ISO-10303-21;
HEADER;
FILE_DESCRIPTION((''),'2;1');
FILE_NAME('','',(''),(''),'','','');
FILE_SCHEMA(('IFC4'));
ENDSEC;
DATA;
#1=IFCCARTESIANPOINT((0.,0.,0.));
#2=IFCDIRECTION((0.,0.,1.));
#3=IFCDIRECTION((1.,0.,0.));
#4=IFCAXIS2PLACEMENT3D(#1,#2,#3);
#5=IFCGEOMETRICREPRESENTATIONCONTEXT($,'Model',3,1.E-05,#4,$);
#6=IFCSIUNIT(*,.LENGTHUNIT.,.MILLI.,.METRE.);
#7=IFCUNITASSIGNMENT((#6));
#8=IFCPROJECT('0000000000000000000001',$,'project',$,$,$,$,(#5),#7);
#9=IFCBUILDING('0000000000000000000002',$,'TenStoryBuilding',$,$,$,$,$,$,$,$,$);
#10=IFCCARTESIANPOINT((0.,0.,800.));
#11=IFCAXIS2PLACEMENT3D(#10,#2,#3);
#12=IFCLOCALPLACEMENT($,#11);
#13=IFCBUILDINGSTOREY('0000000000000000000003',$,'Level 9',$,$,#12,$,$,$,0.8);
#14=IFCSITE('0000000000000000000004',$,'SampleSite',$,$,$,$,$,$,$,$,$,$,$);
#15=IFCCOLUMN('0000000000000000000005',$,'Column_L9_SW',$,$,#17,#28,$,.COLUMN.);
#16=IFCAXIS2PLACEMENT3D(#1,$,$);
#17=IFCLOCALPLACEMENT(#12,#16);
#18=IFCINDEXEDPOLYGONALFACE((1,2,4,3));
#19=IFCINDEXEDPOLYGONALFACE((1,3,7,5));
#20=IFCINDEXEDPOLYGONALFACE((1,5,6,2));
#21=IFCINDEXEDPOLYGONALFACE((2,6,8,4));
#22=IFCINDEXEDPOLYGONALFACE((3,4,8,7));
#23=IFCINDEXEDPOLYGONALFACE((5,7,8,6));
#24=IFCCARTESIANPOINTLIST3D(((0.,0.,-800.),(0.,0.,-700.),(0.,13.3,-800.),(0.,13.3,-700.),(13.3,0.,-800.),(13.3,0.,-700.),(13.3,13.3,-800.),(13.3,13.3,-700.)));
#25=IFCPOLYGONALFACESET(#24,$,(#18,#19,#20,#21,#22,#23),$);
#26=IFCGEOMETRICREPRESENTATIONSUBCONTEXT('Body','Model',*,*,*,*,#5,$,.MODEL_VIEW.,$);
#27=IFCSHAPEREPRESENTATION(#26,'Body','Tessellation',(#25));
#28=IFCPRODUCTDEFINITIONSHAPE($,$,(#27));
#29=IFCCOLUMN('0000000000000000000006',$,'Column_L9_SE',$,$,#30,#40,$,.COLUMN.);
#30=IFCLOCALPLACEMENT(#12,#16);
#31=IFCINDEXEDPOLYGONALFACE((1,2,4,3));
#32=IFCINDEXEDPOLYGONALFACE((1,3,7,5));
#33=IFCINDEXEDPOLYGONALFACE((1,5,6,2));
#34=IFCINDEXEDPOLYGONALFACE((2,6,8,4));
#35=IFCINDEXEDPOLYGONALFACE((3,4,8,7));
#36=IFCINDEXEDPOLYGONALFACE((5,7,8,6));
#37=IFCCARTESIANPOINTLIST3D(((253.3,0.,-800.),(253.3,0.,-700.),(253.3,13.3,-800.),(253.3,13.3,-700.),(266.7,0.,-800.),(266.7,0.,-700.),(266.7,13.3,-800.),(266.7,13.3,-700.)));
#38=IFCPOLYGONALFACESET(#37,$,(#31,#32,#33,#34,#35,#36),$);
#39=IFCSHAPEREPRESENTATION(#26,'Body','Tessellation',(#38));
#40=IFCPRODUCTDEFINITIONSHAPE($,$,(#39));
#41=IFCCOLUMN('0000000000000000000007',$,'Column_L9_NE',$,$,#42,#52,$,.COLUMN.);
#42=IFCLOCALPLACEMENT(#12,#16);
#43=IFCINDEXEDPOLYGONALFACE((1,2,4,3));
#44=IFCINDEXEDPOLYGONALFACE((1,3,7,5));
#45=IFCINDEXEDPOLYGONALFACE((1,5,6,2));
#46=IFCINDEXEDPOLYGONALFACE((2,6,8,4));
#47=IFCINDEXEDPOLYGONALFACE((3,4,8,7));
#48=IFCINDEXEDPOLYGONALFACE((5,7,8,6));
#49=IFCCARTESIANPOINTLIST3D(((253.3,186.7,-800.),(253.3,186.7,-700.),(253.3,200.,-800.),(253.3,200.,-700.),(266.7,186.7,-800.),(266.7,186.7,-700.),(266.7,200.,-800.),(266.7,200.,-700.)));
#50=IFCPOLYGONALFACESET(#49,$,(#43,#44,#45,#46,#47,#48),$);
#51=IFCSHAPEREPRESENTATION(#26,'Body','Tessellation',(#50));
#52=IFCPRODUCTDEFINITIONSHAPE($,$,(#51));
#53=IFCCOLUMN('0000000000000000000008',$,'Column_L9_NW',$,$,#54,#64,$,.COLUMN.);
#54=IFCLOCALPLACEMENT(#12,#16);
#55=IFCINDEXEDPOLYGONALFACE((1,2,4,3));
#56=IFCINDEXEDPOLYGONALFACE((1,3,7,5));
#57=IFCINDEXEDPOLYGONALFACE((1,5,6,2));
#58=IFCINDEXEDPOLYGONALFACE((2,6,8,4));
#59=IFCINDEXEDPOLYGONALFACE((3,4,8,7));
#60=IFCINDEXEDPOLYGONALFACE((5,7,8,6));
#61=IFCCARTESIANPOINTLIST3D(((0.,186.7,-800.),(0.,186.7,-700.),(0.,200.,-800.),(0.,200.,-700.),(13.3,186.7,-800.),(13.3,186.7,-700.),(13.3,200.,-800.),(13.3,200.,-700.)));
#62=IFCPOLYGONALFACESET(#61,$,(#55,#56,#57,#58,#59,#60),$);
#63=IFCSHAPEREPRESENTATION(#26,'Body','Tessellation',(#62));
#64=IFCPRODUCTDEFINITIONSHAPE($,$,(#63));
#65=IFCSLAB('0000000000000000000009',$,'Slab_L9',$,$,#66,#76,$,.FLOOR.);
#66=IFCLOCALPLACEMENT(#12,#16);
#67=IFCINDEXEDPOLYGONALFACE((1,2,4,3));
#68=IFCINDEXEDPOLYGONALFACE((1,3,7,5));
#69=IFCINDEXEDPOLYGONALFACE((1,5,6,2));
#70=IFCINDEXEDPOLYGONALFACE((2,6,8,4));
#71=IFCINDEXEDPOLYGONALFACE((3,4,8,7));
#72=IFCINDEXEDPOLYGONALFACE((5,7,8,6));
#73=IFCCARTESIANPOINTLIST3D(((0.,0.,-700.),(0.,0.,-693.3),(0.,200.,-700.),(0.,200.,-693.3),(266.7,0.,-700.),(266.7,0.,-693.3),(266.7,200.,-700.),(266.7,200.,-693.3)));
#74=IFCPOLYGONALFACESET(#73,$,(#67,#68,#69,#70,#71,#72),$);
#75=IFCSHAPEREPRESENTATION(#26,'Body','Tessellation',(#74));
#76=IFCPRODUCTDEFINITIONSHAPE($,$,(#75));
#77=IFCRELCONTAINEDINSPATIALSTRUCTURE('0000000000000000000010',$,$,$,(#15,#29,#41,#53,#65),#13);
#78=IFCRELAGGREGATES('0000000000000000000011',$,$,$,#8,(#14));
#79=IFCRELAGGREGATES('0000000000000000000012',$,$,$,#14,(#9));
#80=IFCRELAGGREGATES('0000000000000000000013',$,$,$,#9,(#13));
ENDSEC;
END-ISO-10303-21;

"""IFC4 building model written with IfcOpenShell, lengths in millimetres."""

from ifc_helpers import new_model, si_unit, frame, origin_with_axes, origin_2d, place, context, subcontext, project, spatial, indexed_curve, rectangle, outline, extrude, element, save


model = new_model("IFC4")

# Units and contexts
model_context = context("Model", 3, precision=1e-05, world=origin_with_axes())
body_context = subcontext(model_context, "Body", "Model", "MODEL_VIEW")
ifc_project = project(units=[si_unit("LENGTHUNIT", "METRE", prefix="MILLI")], contexts=[model_context])

# Site, building, storey
site = spatial("IfcSite", under=ifc_project, Name="SampleSite")
building = spatial("IfcBuilding", under=site, Name="TenStoryBuilding")
storey_placement = place(None, frame((0.0, 0.0, 800.0), z_axis=(0.0, 0.0, 1.0), x_axis=(1.0, 0.0, 0.0)))
storey = spatial("IfcBuildingStorey", under=building, at=storey_placement, Name="Level 9", Elevation=0.8)

# Columns
for number, where, z_axis, x_axis, name in (
    (1, (6.7, 6.7, -800.0), (0.0, 0.0, 1.0), (1.0, 0.0, 0.0), "Column_L9_SW"),
    (2, (260.0, 6.7, -800.0), (0.0, 0.0, 1.0), (1.0, 0.0, 0.0), "Column_L9_SE"),
    (3, (260.0, 193.3, -800.0), (0.0, 0.0, 1.0), (1.0, 0.0, 0.0), "Column_L9_NE"),
    (4, (6.7, 193.3, -800.0), (0.0, 0.0, 1.0), (1.0, 0.0, 0.0), "Column_L9_NW"),
):
    element("IfcColumn", number, at=place(storey_placement, frame(where, z_axis=z_axis, x_axis=x_axis)), inside=storey, Name=name, PredefinedType="COLUMN", context=body_context, shape_type="SweptSolid", body=[
        extrude(rectangle(XDim=13.3, YDim=13.3, at=origin_2d()), origin_with_axes(), (0.0, 0.0, 1.0), 100.0),
    ])

# Slab
slab_placement = place(storey_placement, frame((0.0, 0.0, -700.0), z_axis=(0.0, 0.0, 1.0), x_axis=(1.0, 0.0, 0.0)))
element("IfcSlab", 5, at=slab_placement, inside=storey, Name="Slab_L9", PredefinedType="FLOOR", context=body_context, shape_type="SweptSolid", body=[
    extrude(outline(indexed_curve([(0.0, 0.0), (266.7, 0.0), (266.7, 200.0), (0.0, 200.0), (0.0, 0.0)])), None, (0.0, 0.0, 1.0), 6.7),
])

save(model, "model.ifc")
